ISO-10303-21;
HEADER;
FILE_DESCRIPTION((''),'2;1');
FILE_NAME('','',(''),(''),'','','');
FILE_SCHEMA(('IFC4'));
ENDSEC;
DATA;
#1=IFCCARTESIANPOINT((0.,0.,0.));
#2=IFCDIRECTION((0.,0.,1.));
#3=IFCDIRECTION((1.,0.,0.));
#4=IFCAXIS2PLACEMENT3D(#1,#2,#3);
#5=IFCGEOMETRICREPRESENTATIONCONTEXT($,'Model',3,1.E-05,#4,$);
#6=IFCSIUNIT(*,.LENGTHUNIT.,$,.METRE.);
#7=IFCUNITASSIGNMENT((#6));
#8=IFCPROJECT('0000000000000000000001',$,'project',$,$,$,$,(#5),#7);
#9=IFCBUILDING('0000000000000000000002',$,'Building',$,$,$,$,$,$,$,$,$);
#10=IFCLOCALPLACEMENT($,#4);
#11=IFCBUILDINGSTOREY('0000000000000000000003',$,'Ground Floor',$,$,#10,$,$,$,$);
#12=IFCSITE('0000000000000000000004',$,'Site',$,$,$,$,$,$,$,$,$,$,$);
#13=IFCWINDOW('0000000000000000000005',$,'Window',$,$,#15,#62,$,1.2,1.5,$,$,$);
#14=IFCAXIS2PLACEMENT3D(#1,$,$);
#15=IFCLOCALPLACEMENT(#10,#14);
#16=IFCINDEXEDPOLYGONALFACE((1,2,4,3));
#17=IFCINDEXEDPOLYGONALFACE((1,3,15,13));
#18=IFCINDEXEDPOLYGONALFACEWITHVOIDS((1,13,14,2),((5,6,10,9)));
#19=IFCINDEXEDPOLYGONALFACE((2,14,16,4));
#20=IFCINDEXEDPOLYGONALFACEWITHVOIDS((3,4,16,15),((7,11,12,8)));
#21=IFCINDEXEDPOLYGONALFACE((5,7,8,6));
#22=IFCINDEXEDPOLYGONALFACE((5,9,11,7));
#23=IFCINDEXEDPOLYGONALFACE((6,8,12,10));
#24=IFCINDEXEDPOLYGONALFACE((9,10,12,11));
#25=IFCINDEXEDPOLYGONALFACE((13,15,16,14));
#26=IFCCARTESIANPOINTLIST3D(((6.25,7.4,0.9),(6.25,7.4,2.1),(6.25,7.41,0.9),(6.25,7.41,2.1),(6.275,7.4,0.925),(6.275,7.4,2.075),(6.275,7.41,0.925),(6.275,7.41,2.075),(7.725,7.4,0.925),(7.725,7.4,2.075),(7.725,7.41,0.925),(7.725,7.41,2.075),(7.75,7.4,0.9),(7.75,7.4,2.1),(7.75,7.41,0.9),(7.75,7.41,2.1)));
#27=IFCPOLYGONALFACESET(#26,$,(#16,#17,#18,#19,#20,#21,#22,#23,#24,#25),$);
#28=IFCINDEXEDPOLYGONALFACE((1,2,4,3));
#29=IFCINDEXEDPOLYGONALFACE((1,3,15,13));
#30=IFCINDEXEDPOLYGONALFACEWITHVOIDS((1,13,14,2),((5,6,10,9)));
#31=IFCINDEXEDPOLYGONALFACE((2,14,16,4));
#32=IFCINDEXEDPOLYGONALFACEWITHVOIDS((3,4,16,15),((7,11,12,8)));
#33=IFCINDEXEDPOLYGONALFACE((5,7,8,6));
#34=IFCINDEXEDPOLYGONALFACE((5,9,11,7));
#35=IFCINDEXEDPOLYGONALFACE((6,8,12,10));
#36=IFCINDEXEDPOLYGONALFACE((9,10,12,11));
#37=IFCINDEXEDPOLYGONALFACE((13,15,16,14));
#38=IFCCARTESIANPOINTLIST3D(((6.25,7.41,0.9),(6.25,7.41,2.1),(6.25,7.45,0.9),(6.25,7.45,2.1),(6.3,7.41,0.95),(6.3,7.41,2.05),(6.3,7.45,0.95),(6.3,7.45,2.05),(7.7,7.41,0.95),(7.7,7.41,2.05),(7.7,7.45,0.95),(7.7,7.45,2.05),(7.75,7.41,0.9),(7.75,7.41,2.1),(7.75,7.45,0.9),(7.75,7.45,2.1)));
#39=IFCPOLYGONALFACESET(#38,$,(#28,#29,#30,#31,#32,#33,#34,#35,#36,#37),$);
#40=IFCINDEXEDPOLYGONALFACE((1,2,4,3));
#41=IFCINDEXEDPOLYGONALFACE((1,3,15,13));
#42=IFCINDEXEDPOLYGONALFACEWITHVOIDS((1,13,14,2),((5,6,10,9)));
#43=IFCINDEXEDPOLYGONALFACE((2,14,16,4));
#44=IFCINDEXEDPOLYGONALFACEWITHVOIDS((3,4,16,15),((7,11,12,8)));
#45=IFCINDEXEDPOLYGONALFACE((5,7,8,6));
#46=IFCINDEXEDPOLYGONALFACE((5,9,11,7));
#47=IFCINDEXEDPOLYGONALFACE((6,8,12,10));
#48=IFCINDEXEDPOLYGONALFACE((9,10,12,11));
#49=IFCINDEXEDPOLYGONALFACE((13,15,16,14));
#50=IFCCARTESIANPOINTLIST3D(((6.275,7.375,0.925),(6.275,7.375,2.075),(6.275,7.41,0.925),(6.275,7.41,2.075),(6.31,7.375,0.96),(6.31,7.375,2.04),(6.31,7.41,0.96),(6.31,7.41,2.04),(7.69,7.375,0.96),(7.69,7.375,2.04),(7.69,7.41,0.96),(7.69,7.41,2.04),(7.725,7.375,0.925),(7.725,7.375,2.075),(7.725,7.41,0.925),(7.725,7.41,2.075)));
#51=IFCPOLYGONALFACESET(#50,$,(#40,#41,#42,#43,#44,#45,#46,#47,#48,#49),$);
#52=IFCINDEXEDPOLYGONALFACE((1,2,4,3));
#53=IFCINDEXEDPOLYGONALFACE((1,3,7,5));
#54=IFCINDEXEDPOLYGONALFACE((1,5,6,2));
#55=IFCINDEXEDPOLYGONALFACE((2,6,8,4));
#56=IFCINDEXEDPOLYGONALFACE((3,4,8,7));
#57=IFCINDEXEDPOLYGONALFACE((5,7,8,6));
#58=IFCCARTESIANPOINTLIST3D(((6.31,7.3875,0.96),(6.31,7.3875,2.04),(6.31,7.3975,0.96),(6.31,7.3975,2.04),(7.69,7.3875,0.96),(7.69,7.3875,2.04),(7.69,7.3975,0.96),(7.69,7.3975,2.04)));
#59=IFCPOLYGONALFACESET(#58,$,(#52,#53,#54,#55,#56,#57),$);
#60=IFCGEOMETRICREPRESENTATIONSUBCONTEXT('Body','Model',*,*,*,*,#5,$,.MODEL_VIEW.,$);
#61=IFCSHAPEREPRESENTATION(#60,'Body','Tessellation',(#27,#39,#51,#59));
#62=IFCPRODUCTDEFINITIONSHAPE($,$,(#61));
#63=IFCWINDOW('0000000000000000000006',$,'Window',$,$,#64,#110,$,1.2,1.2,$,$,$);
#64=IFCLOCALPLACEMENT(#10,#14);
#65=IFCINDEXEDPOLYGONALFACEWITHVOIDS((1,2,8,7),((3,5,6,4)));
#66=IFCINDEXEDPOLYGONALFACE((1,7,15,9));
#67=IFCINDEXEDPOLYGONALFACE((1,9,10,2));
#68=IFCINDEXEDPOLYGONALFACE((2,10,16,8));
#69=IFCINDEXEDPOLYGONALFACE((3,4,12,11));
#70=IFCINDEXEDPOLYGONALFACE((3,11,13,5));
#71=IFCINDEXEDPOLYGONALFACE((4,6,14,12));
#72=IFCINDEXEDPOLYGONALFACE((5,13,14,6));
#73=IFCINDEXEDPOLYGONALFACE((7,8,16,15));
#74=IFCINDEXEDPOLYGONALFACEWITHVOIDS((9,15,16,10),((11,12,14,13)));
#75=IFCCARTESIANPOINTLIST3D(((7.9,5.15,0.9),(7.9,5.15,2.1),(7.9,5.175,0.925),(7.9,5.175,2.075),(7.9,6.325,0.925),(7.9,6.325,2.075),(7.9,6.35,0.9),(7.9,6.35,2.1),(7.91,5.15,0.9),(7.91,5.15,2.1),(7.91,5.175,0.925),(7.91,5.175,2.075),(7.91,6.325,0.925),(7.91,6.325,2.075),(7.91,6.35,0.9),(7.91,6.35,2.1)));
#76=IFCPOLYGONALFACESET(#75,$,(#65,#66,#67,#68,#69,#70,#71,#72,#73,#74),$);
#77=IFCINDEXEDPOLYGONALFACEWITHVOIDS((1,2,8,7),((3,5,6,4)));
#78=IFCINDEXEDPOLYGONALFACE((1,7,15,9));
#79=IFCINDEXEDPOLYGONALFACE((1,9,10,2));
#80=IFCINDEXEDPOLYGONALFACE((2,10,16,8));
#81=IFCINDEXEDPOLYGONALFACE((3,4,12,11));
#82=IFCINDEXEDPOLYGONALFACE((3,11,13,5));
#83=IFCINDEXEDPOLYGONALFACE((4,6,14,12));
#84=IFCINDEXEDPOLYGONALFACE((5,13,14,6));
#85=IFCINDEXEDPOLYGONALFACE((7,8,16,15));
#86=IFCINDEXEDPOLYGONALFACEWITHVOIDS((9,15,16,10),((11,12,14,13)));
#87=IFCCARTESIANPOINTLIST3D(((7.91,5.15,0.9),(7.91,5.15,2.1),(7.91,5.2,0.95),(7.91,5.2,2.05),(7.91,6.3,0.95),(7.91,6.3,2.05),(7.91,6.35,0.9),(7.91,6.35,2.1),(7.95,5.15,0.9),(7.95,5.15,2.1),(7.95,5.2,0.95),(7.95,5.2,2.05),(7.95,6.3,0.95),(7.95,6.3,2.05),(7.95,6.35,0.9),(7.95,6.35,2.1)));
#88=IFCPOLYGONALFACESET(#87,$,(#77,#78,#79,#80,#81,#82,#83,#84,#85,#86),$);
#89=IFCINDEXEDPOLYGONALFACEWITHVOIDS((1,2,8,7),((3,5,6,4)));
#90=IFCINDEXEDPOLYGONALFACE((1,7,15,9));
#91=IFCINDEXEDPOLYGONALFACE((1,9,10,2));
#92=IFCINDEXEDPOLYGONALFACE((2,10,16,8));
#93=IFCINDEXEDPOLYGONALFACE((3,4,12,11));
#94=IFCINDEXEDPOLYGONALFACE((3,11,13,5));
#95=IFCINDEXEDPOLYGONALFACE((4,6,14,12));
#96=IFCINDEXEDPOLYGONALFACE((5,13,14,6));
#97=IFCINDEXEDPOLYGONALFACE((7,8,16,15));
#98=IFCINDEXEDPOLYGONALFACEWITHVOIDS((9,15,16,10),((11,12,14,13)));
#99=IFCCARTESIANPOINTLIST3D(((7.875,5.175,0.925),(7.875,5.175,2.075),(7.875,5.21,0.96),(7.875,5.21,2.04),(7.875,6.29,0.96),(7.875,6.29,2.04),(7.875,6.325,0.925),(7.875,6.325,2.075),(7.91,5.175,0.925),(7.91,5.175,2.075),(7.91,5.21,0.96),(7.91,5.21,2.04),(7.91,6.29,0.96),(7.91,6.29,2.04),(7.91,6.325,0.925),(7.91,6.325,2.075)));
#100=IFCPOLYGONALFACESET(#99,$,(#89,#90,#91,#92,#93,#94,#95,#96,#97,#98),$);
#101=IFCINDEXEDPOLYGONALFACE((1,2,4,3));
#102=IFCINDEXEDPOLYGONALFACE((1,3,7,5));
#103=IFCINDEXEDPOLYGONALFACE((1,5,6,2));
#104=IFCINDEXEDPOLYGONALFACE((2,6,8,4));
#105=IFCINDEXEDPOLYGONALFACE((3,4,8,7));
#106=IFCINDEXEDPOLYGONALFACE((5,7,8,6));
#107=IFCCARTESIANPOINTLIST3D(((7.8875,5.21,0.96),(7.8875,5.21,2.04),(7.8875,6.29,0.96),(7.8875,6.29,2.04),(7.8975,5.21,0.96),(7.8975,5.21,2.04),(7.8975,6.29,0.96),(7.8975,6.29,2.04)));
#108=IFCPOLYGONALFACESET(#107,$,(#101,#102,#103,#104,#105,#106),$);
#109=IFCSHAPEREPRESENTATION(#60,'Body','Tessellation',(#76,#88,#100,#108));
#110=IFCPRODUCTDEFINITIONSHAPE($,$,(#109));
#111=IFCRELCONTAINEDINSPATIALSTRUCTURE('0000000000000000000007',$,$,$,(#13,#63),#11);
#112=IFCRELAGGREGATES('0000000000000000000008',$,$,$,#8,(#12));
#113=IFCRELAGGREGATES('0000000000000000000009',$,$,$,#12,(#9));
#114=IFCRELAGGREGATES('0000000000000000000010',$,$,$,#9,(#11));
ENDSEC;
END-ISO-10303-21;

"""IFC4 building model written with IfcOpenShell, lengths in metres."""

from ifc_helpers import new_model, si_unit, frame, origin_with_axes, place, context, subcontext, project, spatial, line, indexed_curve, outline, extrude, element, save


model = new_model("IFC4")

# Units and contexts
model_context = context("Model", 3, precision=1e-05, world=origin_with_axes())
body_context = subcontext(model_context, "Body", "Model", "MODEL_VIEW")
ifc_project = project(units=[si_unit("LENGTHUNIT", "METRE")], contexts=[model_context])

# Site, building, storey
site = spatial("IfcSite", under=ifc_project, Name="Site")
building = spatial("IfcBuilding", under=site, Name="Building")
storey_placement = place(None, origin_with_axes())
storey = spatial("IfcBuildingStorey", under=building, at=storey_placement, Name="Ground Floor")

# Windows
window_1_placement = place(storey_placement, frame((7.75, 7.5, 0.9), z_axis=(0.0, 0.0, 1.0), x_axis=(-1.0, 0.0, 0.0)))
element("IfcWindow", 1, at=window_1_placement, inside=storey, Name="Window", OverallHeight=1.2, OverallWidth=1.5, context=body_context, shape_type="SweptSolid", body=[
    extrude(outline(indexed_curve([(0.0, 0.0), (1.5, 0.0), (1.5, 1.2), (0.0, 1.2)], segments=[line(1, 2, 3, 4, 1)]), holes=[indexed_curve([(0.025, 0.025), (1.475, 0.025), (1.475, 1.175), (0.025, 1.175)], segments=[line(1, 2, 3, 4, 1)])]), frame((0.0, 0.09, 0.0), z_axis=(0.0, -1.0, 0.0), x_axis=(1.0, 0.0, 0.0)), (0.0, 0.0, -1.0), 0.01),
    extrude(outline(indexed_curve([(0.0, 0.0), (1.5, 0.0), (1.5, 1.2), (0.0, 1.2)], segments=[line(1, 2, 3, 4, 1)]), holes=[indexed_curve([(0.05, 0.05), (1.45, 0.05), (1.45, 1.15), (0.05, 1.15)], segments=[line(1, 2, 3, 4, 1)])]), frame((0.0, 0.05, 0.0), z_axis=(0.0, -1.0, 0.0), x_axis=(1.0, 0.0, 0.0)), (0.0, 0.0, -1.0), 0.04),
    extrude(outline(indexed_curve([(0.0, 0.0), (1.45, 0.0), (1.45, 1.15), (0.0, 1.15)], segments=[line(1, 2, 3, 4, 1)]), holes=[indexed_curve([(0.035, 0.035), (1.415, 0.035), (1.415, 1.115), (0.035, 1.115)], segments=[line(1, 2, 3, 4, 1)])]), frame((0.025, 0.09, 0.025), z_axis=(0.0, -1.0, 0.0), x_axis=(1.0, 0.0, 0.0)), (0.0, 0.0, -1.0), 0.035),
    extrude(outline(indexed_curve([(0.035, 0.035), (1.415, 0.035), (1.415, 1.115), (0.035, 1.115)], segments=[line(1, 2, 3, 4, 1)])), frame((0.025, 0.1025, 0.025), z_axis=(0.0, -1.0, 0.0), x_axis=(1.0, 0.0, 0.0)), (0.0, 0.0, -1.0), 0.01),
])
window_2_placement = place(storey_placement, frame((8.0, 5.15, 0.9), z_axis=(0.0, 0.0, 1.0), x_axis=(0.0, 1.0, 0.0)))
element("IfcWindow", 2, at=window_2_placement, inside=storey, Name="Window", OverallHeight=1.2, OverallWidth=1.2, context=body_context, shape_type="SweptSolid", body=[
    extrude(outline(indexed_curve([(0.0, 0.0), (1.2, 0.0), (1.2, 1.2), (0.0, 1.2)], segments=[line(1, 2, 3, 4, 1)]), holes=[indexed_curve([(0.025, 0.025), (1.175, 0.025), (1.175, 1.175), (0.025, 1.175)], segments=[line(1, 2, 3, 4, 1)])]), frame((0.0, 0.09, 0.0), z_axis=(0.0, -1.0, 0.0), x_axis=(1.0, 0.0, 0.0)), (0.0, 0.0, -1.0), 0.01),
    extrude(outline(indexed_curve([(0.0, 0.0), (1.2, 0.0), (1.2, 1.2), (0.0, 1.2)], segments=[line(1, 2, 3, 4, 1)]), holes=[indexed_curve([(0.05, 0.05), (1.15, 0.05), (1.15, 1.15), (0.05, 1.15)], segments=[line(1, 2, 3, 4, 1)])]), frame((0.0, 0.05, 0.0), z_axis=(0.0, -1.0, 0.0), x_axis=(1.0, 0.0, 0.0)), (0.0, 0.0, -1.0), 0.04),
    extrude(outline(indexed_curve([(0.0, 0.0), (1.15, 0.0), (1.15, 1.15), (0.0, 1.15)], segments=[line(1, 2, 3, 4, 1)]), holes=[indexed_curve([(0.035, 0.035), (1.115, 0.035), (1.115, 1.115), (0.035, 1.115)], segments=[line(1, 2, 3, 4, 1)])]), frame((0.025, 0.09, 0.025), z_axis=(0.0, -1.0, 0.0), x_axis=(1.0, 0.0, 0.0)), (0.0, 0.0, -1.0), 0.035),
    extrude(outline(indexed_curve([(0.035, 0.035), (1.115, 0.035), (1.115, 1.115), (0.035, 1.115)], segments=[line(1, 2, 3, 4, 1)])), frame((0.025, 0.1025, 0.025), z_axis=(0.0, -1.0, 0.0), x_axis=(1.0, 0.0, 0.0)), (0.0, 0.0, -1.0), 0.01),
])

save(model, "model.ifc")
